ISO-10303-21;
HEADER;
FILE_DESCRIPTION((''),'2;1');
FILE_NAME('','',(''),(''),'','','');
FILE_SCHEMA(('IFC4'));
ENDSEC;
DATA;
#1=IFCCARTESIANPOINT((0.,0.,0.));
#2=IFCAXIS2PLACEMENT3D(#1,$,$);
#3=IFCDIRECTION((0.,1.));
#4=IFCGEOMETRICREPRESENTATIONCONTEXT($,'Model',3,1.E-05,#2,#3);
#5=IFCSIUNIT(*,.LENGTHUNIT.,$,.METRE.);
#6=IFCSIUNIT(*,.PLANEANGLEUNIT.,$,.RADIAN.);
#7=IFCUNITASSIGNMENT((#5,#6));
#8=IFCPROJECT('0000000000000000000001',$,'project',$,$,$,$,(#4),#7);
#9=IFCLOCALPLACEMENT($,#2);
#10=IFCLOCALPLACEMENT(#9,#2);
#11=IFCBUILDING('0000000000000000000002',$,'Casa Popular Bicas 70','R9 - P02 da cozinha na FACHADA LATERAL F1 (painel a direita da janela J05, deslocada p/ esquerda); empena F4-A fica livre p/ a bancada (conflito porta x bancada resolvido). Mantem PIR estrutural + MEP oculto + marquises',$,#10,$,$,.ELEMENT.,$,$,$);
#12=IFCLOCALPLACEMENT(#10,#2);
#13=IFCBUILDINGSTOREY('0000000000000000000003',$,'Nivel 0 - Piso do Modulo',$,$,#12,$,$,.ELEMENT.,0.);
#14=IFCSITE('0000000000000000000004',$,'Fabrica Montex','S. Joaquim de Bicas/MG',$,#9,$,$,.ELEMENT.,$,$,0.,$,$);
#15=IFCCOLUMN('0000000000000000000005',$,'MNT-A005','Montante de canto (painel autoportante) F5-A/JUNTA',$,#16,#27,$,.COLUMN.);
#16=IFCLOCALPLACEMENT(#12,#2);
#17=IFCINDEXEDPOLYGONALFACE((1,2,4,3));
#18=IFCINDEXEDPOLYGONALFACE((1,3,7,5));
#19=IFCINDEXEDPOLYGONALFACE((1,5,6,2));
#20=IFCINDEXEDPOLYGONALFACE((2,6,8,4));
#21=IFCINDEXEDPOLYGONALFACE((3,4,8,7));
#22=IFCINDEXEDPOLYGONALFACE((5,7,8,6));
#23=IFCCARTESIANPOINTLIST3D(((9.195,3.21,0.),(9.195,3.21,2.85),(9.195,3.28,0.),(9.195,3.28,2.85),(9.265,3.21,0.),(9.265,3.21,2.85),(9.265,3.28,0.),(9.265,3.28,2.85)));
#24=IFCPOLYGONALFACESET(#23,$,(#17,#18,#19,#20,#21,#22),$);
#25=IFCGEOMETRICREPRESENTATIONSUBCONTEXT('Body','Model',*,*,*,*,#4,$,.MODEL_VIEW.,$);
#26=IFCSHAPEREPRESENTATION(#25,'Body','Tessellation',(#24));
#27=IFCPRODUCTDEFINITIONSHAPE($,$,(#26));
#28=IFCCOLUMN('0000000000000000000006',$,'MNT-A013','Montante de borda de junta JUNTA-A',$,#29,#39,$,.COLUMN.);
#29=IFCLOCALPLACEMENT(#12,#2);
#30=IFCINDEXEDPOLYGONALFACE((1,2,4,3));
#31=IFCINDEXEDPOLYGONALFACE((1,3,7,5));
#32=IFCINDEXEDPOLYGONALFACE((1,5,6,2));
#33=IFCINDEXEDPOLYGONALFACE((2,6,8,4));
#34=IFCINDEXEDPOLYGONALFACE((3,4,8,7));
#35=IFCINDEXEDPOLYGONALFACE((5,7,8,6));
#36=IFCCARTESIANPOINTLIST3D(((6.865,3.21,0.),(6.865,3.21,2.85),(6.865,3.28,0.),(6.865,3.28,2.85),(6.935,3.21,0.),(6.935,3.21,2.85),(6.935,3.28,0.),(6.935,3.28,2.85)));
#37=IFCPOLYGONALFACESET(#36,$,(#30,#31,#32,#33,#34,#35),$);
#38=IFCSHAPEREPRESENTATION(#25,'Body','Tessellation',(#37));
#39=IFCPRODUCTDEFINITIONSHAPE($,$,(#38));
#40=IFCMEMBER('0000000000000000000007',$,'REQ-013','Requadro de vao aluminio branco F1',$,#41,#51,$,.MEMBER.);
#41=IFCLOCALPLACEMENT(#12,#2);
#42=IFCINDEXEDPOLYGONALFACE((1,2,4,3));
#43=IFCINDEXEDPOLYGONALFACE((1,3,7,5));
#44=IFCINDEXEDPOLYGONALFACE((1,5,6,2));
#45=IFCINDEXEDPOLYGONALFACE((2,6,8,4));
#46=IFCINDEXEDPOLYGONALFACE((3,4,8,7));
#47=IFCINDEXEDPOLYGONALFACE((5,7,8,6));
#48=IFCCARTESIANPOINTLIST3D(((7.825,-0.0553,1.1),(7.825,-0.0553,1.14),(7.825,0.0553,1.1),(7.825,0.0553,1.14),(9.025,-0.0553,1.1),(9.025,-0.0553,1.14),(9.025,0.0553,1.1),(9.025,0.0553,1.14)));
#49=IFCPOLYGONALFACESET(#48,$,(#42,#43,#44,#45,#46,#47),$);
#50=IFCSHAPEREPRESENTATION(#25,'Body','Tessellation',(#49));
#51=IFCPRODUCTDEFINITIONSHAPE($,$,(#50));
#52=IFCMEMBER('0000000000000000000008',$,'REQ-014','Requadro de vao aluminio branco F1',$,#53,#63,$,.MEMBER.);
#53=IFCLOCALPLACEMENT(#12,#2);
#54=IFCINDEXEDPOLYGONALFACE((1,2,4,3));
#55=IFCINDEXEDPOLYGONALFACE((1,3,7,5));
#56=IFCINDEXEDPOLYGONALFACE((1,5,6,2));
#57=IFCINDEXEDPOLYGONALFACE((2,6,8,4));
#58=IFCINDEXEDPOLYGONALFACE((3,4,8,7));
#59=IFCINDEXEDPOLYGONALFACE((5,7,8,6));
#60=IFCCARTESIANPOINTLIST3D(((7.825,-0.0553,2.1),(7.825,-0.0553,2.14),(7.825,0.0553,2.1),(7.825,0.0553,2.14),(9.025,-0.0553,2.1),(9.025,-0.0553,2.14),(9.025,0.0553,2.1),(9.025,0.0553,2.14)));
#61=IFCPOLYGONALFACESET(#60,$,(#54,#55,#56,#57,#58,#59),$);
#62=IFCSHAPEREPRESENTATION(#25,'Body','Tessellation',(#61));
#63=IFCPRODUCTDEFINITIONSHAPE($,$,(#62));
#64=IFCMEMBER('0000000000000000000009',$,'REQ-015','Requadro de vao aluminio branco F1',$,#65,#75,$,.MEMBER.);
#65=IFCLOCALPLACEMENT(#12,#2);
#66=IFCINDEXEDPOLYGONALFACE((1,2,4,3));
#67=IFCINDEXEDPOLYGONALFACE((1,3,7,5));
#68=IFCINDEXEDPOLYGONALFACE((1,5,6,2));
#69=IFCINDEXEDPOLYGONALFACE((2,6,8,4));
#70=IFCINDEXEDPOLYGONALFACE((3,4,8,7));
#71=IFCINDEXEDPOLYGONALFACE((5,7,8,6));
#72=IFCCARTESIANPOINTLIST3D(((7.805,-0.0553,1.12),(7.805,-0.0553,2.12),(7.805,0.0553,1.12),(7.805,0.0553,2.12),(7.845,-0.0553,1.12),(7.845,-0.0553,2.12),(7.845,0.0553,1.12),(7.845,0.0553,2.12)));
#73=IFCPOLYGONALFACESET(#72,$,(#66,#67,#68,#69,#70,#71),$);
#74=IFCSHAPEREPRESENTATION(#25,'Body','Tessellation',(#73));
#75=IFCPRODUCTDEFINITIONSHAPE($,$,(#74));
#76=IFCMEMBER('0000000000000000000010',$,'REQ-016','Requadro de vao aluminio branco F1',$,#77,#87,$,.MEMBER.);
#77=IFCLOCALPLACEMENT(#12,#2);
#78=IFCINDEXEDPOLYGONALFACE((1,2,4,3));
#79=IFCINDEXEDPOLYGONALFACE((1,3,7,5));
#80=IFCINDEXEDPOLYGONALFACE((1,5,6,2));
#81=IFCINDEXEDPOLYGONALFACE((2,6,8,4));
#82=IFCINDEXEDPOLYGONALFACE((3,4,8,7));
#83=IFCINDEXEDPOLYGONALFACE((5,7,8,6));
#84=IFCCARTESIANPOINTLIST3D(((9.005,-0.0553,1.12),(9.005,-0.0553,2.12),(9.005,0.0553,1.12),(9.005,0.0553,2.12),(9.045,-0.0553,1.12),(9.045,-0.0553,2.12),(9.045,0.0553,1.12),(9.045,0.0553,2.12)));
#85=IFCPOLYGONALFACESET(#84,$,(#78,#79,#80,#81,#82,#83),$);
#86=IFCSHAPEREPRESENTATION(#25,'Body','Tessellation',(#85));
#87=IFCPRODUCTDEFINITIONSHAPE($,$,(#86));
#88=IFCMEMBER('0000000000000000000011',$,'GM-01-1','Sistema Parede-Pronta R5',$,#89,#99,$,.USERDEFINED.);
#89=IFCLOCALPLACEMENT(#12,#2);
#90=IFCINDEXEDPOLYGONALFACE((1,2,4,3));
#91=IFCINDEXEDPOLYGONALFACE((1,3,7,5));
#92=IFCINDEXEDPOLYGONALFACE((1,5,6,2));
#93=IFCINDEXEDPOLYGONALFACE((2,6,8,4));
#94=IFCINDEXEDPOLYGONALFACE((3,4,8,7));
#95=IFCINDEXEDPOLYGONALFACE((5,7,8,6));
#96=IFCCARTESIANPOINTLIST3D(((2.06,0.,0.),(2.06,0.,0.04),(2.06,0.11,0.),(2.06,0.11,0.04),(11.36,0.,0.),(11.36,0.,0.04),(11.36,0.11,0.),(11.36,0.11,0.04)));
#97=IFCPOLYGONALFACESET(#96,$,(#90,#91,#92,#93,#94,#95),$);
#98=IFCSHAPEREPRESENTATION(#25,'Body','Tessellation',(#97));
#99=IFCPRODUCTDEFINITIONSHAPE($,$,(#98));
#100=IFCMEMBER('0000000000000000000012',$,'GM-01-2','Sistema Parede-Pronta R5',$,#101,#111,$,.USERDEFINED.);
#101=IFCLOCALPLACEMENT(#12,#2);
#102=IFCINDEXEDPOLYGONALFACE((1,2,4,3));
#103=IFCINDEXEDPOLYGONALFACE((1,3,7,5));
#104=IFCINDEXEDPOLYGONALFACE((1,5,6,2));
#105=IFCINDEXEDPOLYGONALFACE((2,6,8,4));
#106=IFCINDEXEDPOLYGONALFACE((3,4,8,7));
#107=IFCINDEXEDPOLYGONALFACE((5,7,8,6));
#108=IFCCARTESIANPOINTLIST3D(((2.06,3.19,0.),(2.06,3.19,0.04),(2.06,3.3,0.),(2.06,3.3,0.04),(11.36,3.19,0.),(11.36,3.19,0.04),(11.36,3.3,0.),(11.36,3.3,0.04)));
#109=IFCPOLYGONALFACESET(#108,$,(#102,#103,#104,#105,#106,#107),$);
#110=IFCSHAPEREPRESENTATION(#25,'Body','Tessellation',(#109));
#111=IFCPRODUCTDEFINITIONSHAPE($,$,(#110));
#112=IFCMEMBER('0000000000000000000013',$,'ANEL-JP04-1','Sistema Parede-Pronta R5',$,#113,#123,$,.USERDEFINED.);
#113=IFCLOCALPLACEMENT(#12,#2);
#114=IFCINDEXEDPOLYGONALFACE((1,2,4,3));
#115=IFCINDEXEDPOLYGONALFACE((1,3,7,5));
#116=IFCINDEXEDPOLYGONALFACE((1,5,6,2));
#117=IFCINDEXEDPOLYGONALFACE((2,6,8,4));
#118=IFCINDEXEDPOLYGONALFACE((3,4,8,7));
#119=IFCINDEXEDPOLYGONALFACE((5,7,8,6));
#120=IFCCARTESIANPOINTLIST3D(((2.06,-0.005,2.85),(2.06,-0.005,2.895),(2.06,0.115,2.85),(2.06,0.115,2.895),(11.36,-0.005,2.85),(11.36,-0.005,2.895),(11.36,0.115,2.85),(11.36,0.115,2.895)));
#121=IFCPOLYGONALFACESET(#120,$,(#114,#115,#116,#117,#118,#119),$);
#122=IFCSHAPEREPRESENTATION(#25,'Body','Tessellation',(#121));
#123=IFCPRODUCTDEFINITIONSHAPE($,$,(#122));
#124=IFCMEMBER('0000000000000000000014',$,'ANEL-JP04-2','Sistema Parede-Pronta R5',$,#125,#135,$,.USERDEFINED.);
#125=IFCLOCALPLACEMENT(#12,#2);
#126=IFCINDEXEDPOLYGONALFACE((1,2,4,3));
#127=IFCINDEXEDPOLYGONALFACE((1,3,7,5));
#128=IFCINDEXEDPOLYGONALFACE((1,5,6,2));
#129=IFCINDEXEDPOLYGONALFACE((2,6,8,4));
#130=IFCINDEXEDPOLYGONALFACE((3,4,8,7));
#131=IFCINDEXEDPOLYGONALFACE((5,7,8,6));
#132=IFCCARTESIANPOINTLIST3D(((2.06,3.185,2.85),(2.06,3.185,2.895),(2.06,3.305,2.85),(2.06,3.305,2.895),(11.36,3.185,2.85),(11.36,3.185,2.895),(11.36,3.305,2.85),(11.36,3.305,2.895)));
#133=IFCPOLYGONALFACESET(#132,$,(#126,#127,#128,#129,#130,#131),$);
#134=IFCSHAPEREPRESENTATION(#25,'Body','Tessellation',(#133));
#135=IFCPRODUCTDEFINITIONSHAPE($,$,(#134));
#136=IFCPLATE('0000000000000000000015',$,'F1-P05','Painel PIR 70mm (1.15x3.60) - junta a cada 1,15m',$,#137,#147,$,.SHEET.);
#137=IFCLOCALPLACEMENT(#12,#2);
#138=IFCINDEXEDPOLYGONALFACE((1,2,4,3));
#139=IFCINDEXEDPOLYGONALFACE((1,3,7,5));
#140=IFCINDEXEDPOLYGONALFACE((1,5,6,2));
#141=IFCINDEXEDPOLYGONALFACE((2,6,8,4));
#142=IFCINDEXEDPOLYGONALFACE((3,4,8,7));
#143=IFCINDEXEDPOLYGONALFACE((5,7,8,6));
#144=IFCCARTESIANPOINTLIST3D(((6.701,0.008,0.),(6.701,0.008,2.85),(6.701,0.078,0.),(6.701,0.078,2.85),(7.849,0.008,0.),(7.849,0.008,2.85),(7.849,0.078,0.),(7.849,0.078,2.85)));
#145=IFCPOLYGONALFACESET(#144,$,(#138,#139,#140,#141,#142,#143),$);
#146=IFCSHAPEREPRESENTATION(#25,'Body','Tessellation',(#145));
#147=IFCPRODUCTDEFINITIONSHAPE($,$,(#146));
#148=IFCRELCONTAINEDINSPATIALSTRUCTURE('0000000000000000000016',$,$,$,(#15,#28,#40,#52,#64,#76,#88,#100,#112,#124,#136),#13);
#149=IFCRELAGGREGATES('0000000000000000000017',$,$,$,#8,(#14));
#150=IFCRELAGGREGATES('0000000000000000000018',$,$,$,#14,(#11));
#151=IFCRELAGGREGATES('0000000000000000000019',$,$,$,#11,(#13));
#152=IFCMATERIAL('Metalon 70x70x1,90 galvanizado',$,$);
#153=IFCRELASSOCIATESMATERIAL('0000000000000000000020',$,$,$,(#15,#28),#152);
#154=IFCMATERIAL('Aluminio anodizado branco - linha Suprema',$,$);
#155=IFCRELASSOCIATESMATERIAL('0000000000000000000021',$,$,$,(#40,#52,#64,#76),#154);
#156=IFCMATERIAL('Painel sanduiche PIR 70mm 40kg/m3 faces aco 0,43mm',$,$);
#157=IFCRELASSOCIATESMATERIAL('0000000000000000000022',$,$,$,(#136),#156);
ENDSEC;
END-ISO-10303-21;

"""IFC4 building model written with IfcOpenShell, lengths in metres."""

from ifc_helpers import new_model, si_unit, direction, frame, frame_2d, origin, origin_2d, place, context, subcontext, project, spatial, rectangle, extrude, material, element, save


model = new_model("IFC4")

# Units and contexts
model_context = context("Model", 3, precision=1e-05, world=origin(), true_north=direction((0.0, 1.0)))
body_context = subcontext(model_context, "Body", "Model", "MODEL_VIEW")
ifc_project = project(units=[si_unit("LENGTHUNIT", "METRE"), si_unit("PLANEANGLEUNIT", "RADIAN")], contexts=[model_context])

# Site, building, storey
site_placement = place(None, origin())
site = spatial("IfcSite", under=ifc_project, at=site_placement, Name="Fabrica Montex", Description="S. Joaquim de Bicas/MG", CompositionType="ELEMENT", RefElevation=0.0)
building_placement = place(site_placement, origin())
building = spatial("IfcBuilding", under=site, at=building_placement, Name="Casa Popular Bicas 70", Description="R9 - P02 da cozinha na FACHADA LATERAL F1 (painel a direita da janela J05, deslocada p/ esquerda); empena F4-A fica livre p/ a bancada (conflito porta x bancada resolvido). Mantem PIR estrutural + MEP oculto + marquises", CompositionType="ELEMENT")
storey_placement = place(building_placement, origin())
storey = spatial("IfcBuildingStorey", under=building, at=storey_placement, Name="Nivel 0 - Piso do Modulo", CompositionType="ELEMENT", Elevation=0.0)

# Columns
ifc_material_1 = material(Name="Metalon 70x70x1,90 galvanizado")
for number, where, name, description in (
    (1, (9.23, 3.245, 0.0), "MNT-A005", "Montante de canto (painel autoportante) F5-A/JUNTA"),
    (2, (6.9, 3.245, 0.0), "MNT-A013", "Montante de borda de junta JUNTA-A"),
):
    element("IfcColumn", number, at=place(storey_placement, frame(where)), inside=storey, material=ifc_material_1, Name=name, Description=description, PredefinedType="COLUMN", context=body_context, shape_type="SweptSolid", body=[
        extrude(rectangle(XDim=0.07, YDim=0.07, at=origin_2d()), origin(), (0.0, 0.0, 1.0), 2.85),
    ])

# Members
ifc_material_2 = material(Name="Aluminio anodizado branco - linha Suprema")
for number, where, z_axis, x_axis, name in (
    (3, (7.825, 0.0, 1.12), (1.0, 0.0, 0.0), (0.0, 0.0, 1.0), "REQ-013"),
    (4, (7.825, 0.0, 2.12), (1.0, 0.0, 0.0), (0.0, 0.0, 1.0), "REQ-014"),
):
    element("IfcMember", number, at=place(storey_placement, frame(where, z_axis=z_axis, x_axis=x_axis)), inside=storey, material=ifc_material_2, Name=name, Description="Requadro de vao aluminio branco F1", PredefinedType="MEMBER", context=body_context, shape_type="SweptSolid", body=[
        extrude(rectangle(XDim=0.04, YDim=0.1105, at=origin_2d()), origin(), (0.0, 0.0, 1.0), 1.2),
    ])
for number, where, z_axis, x_axis, name in (
    (5, (7.825, 0.0, 1.12), (0.0, 0.0, 1.0), (1.0, 0.0, 0.0), "REQ-015"),
    (6, (9.025, 0.0, 1.12), (0.0, 0.0, 1.0), (1.0, 0.0, 0.0), "REQ-016"),
):
    element("IfcMember", number, at=place(storey_placement, frame(where, z_axis=z_axis, x_axis=x_axis)), inside=storey, material=ifc_material_2, Name=name, Description="Requadro de vao aluminio branco F1", PredefinedType="MEMBER", context=body_context, shape_type="SweptSolid", body=[
        extrude(rectangle(XDim=0.04, YDim=0.1105, at=origin_2d()), origin(), (0.0, 0.0, 1.0), 1.0),
    ])
for number, where, name in (
    (7, (6.71, 0.055, 0.0), "GM-01-1"),
    (8, (6.71, 3.245, 0.0), "GM-01-2"),
):
    element("IfcMember", number, at=place(storey_placement, frame(where)), inside=storey, Name=name, Description="Sistema Parede-Pronta R5", PredefinedType="USERDEFINED", context=body_context, shape_type="SweptSolid", body=[
        extrude(rectangle(XDim=9.3, YDim=0.11, at=origin_2d()), origin(), (0.0, 0.0, 1.0), 0.04),
    ])
for number, where, name in (
    (9, (6.71, 0.055, 2.85), "ANEL-JP04-1"),
    (10, (6.71, 3.245, 2.85), "ANEL-JP04-2"),
):
    element("IfcMember", number, at=place(storey_placement, frame(where)), inside=storey, Name=name, Description="Sistema Parede-Pronta R5", PredefinedType="USERDEFINED", context=body_context, shape_type="SweptSolid", body=[
        extrude(rectangle(XDim=9.3, YDim=0.12, at=origin_2d()), origin(), (0.0, 0.0, 1.0), 0.045),
    ])

# Plate
ifc_material_3 = material(Name="Painel sanduiche PIR 70mm 40kg/m3 faces aco 0,43mm")
plate_1_placement = place(storey_placement, frame((6.701, 0.043, 0.0), x_axis=(1.0, 0.0, 0.0)))
element("IfcPlate", 11, at=plate_1_placement, inside=storey, material=ifc_material_3, Name="F1-P05", Description="Painel PIR 70mm (1.15x3.60) - junta a cada 1,15m", PredefinedType="SHEET", context=body_context, shape_type="SweptSolid", body=[
    extrude(rectangle(XDim=1.148, YDim=0.07, at=frame_2d((0.574, 0.0))), origin(), (0.0, 0.0, 1.0), 2.85),
])

save(model, "model.ifc")
